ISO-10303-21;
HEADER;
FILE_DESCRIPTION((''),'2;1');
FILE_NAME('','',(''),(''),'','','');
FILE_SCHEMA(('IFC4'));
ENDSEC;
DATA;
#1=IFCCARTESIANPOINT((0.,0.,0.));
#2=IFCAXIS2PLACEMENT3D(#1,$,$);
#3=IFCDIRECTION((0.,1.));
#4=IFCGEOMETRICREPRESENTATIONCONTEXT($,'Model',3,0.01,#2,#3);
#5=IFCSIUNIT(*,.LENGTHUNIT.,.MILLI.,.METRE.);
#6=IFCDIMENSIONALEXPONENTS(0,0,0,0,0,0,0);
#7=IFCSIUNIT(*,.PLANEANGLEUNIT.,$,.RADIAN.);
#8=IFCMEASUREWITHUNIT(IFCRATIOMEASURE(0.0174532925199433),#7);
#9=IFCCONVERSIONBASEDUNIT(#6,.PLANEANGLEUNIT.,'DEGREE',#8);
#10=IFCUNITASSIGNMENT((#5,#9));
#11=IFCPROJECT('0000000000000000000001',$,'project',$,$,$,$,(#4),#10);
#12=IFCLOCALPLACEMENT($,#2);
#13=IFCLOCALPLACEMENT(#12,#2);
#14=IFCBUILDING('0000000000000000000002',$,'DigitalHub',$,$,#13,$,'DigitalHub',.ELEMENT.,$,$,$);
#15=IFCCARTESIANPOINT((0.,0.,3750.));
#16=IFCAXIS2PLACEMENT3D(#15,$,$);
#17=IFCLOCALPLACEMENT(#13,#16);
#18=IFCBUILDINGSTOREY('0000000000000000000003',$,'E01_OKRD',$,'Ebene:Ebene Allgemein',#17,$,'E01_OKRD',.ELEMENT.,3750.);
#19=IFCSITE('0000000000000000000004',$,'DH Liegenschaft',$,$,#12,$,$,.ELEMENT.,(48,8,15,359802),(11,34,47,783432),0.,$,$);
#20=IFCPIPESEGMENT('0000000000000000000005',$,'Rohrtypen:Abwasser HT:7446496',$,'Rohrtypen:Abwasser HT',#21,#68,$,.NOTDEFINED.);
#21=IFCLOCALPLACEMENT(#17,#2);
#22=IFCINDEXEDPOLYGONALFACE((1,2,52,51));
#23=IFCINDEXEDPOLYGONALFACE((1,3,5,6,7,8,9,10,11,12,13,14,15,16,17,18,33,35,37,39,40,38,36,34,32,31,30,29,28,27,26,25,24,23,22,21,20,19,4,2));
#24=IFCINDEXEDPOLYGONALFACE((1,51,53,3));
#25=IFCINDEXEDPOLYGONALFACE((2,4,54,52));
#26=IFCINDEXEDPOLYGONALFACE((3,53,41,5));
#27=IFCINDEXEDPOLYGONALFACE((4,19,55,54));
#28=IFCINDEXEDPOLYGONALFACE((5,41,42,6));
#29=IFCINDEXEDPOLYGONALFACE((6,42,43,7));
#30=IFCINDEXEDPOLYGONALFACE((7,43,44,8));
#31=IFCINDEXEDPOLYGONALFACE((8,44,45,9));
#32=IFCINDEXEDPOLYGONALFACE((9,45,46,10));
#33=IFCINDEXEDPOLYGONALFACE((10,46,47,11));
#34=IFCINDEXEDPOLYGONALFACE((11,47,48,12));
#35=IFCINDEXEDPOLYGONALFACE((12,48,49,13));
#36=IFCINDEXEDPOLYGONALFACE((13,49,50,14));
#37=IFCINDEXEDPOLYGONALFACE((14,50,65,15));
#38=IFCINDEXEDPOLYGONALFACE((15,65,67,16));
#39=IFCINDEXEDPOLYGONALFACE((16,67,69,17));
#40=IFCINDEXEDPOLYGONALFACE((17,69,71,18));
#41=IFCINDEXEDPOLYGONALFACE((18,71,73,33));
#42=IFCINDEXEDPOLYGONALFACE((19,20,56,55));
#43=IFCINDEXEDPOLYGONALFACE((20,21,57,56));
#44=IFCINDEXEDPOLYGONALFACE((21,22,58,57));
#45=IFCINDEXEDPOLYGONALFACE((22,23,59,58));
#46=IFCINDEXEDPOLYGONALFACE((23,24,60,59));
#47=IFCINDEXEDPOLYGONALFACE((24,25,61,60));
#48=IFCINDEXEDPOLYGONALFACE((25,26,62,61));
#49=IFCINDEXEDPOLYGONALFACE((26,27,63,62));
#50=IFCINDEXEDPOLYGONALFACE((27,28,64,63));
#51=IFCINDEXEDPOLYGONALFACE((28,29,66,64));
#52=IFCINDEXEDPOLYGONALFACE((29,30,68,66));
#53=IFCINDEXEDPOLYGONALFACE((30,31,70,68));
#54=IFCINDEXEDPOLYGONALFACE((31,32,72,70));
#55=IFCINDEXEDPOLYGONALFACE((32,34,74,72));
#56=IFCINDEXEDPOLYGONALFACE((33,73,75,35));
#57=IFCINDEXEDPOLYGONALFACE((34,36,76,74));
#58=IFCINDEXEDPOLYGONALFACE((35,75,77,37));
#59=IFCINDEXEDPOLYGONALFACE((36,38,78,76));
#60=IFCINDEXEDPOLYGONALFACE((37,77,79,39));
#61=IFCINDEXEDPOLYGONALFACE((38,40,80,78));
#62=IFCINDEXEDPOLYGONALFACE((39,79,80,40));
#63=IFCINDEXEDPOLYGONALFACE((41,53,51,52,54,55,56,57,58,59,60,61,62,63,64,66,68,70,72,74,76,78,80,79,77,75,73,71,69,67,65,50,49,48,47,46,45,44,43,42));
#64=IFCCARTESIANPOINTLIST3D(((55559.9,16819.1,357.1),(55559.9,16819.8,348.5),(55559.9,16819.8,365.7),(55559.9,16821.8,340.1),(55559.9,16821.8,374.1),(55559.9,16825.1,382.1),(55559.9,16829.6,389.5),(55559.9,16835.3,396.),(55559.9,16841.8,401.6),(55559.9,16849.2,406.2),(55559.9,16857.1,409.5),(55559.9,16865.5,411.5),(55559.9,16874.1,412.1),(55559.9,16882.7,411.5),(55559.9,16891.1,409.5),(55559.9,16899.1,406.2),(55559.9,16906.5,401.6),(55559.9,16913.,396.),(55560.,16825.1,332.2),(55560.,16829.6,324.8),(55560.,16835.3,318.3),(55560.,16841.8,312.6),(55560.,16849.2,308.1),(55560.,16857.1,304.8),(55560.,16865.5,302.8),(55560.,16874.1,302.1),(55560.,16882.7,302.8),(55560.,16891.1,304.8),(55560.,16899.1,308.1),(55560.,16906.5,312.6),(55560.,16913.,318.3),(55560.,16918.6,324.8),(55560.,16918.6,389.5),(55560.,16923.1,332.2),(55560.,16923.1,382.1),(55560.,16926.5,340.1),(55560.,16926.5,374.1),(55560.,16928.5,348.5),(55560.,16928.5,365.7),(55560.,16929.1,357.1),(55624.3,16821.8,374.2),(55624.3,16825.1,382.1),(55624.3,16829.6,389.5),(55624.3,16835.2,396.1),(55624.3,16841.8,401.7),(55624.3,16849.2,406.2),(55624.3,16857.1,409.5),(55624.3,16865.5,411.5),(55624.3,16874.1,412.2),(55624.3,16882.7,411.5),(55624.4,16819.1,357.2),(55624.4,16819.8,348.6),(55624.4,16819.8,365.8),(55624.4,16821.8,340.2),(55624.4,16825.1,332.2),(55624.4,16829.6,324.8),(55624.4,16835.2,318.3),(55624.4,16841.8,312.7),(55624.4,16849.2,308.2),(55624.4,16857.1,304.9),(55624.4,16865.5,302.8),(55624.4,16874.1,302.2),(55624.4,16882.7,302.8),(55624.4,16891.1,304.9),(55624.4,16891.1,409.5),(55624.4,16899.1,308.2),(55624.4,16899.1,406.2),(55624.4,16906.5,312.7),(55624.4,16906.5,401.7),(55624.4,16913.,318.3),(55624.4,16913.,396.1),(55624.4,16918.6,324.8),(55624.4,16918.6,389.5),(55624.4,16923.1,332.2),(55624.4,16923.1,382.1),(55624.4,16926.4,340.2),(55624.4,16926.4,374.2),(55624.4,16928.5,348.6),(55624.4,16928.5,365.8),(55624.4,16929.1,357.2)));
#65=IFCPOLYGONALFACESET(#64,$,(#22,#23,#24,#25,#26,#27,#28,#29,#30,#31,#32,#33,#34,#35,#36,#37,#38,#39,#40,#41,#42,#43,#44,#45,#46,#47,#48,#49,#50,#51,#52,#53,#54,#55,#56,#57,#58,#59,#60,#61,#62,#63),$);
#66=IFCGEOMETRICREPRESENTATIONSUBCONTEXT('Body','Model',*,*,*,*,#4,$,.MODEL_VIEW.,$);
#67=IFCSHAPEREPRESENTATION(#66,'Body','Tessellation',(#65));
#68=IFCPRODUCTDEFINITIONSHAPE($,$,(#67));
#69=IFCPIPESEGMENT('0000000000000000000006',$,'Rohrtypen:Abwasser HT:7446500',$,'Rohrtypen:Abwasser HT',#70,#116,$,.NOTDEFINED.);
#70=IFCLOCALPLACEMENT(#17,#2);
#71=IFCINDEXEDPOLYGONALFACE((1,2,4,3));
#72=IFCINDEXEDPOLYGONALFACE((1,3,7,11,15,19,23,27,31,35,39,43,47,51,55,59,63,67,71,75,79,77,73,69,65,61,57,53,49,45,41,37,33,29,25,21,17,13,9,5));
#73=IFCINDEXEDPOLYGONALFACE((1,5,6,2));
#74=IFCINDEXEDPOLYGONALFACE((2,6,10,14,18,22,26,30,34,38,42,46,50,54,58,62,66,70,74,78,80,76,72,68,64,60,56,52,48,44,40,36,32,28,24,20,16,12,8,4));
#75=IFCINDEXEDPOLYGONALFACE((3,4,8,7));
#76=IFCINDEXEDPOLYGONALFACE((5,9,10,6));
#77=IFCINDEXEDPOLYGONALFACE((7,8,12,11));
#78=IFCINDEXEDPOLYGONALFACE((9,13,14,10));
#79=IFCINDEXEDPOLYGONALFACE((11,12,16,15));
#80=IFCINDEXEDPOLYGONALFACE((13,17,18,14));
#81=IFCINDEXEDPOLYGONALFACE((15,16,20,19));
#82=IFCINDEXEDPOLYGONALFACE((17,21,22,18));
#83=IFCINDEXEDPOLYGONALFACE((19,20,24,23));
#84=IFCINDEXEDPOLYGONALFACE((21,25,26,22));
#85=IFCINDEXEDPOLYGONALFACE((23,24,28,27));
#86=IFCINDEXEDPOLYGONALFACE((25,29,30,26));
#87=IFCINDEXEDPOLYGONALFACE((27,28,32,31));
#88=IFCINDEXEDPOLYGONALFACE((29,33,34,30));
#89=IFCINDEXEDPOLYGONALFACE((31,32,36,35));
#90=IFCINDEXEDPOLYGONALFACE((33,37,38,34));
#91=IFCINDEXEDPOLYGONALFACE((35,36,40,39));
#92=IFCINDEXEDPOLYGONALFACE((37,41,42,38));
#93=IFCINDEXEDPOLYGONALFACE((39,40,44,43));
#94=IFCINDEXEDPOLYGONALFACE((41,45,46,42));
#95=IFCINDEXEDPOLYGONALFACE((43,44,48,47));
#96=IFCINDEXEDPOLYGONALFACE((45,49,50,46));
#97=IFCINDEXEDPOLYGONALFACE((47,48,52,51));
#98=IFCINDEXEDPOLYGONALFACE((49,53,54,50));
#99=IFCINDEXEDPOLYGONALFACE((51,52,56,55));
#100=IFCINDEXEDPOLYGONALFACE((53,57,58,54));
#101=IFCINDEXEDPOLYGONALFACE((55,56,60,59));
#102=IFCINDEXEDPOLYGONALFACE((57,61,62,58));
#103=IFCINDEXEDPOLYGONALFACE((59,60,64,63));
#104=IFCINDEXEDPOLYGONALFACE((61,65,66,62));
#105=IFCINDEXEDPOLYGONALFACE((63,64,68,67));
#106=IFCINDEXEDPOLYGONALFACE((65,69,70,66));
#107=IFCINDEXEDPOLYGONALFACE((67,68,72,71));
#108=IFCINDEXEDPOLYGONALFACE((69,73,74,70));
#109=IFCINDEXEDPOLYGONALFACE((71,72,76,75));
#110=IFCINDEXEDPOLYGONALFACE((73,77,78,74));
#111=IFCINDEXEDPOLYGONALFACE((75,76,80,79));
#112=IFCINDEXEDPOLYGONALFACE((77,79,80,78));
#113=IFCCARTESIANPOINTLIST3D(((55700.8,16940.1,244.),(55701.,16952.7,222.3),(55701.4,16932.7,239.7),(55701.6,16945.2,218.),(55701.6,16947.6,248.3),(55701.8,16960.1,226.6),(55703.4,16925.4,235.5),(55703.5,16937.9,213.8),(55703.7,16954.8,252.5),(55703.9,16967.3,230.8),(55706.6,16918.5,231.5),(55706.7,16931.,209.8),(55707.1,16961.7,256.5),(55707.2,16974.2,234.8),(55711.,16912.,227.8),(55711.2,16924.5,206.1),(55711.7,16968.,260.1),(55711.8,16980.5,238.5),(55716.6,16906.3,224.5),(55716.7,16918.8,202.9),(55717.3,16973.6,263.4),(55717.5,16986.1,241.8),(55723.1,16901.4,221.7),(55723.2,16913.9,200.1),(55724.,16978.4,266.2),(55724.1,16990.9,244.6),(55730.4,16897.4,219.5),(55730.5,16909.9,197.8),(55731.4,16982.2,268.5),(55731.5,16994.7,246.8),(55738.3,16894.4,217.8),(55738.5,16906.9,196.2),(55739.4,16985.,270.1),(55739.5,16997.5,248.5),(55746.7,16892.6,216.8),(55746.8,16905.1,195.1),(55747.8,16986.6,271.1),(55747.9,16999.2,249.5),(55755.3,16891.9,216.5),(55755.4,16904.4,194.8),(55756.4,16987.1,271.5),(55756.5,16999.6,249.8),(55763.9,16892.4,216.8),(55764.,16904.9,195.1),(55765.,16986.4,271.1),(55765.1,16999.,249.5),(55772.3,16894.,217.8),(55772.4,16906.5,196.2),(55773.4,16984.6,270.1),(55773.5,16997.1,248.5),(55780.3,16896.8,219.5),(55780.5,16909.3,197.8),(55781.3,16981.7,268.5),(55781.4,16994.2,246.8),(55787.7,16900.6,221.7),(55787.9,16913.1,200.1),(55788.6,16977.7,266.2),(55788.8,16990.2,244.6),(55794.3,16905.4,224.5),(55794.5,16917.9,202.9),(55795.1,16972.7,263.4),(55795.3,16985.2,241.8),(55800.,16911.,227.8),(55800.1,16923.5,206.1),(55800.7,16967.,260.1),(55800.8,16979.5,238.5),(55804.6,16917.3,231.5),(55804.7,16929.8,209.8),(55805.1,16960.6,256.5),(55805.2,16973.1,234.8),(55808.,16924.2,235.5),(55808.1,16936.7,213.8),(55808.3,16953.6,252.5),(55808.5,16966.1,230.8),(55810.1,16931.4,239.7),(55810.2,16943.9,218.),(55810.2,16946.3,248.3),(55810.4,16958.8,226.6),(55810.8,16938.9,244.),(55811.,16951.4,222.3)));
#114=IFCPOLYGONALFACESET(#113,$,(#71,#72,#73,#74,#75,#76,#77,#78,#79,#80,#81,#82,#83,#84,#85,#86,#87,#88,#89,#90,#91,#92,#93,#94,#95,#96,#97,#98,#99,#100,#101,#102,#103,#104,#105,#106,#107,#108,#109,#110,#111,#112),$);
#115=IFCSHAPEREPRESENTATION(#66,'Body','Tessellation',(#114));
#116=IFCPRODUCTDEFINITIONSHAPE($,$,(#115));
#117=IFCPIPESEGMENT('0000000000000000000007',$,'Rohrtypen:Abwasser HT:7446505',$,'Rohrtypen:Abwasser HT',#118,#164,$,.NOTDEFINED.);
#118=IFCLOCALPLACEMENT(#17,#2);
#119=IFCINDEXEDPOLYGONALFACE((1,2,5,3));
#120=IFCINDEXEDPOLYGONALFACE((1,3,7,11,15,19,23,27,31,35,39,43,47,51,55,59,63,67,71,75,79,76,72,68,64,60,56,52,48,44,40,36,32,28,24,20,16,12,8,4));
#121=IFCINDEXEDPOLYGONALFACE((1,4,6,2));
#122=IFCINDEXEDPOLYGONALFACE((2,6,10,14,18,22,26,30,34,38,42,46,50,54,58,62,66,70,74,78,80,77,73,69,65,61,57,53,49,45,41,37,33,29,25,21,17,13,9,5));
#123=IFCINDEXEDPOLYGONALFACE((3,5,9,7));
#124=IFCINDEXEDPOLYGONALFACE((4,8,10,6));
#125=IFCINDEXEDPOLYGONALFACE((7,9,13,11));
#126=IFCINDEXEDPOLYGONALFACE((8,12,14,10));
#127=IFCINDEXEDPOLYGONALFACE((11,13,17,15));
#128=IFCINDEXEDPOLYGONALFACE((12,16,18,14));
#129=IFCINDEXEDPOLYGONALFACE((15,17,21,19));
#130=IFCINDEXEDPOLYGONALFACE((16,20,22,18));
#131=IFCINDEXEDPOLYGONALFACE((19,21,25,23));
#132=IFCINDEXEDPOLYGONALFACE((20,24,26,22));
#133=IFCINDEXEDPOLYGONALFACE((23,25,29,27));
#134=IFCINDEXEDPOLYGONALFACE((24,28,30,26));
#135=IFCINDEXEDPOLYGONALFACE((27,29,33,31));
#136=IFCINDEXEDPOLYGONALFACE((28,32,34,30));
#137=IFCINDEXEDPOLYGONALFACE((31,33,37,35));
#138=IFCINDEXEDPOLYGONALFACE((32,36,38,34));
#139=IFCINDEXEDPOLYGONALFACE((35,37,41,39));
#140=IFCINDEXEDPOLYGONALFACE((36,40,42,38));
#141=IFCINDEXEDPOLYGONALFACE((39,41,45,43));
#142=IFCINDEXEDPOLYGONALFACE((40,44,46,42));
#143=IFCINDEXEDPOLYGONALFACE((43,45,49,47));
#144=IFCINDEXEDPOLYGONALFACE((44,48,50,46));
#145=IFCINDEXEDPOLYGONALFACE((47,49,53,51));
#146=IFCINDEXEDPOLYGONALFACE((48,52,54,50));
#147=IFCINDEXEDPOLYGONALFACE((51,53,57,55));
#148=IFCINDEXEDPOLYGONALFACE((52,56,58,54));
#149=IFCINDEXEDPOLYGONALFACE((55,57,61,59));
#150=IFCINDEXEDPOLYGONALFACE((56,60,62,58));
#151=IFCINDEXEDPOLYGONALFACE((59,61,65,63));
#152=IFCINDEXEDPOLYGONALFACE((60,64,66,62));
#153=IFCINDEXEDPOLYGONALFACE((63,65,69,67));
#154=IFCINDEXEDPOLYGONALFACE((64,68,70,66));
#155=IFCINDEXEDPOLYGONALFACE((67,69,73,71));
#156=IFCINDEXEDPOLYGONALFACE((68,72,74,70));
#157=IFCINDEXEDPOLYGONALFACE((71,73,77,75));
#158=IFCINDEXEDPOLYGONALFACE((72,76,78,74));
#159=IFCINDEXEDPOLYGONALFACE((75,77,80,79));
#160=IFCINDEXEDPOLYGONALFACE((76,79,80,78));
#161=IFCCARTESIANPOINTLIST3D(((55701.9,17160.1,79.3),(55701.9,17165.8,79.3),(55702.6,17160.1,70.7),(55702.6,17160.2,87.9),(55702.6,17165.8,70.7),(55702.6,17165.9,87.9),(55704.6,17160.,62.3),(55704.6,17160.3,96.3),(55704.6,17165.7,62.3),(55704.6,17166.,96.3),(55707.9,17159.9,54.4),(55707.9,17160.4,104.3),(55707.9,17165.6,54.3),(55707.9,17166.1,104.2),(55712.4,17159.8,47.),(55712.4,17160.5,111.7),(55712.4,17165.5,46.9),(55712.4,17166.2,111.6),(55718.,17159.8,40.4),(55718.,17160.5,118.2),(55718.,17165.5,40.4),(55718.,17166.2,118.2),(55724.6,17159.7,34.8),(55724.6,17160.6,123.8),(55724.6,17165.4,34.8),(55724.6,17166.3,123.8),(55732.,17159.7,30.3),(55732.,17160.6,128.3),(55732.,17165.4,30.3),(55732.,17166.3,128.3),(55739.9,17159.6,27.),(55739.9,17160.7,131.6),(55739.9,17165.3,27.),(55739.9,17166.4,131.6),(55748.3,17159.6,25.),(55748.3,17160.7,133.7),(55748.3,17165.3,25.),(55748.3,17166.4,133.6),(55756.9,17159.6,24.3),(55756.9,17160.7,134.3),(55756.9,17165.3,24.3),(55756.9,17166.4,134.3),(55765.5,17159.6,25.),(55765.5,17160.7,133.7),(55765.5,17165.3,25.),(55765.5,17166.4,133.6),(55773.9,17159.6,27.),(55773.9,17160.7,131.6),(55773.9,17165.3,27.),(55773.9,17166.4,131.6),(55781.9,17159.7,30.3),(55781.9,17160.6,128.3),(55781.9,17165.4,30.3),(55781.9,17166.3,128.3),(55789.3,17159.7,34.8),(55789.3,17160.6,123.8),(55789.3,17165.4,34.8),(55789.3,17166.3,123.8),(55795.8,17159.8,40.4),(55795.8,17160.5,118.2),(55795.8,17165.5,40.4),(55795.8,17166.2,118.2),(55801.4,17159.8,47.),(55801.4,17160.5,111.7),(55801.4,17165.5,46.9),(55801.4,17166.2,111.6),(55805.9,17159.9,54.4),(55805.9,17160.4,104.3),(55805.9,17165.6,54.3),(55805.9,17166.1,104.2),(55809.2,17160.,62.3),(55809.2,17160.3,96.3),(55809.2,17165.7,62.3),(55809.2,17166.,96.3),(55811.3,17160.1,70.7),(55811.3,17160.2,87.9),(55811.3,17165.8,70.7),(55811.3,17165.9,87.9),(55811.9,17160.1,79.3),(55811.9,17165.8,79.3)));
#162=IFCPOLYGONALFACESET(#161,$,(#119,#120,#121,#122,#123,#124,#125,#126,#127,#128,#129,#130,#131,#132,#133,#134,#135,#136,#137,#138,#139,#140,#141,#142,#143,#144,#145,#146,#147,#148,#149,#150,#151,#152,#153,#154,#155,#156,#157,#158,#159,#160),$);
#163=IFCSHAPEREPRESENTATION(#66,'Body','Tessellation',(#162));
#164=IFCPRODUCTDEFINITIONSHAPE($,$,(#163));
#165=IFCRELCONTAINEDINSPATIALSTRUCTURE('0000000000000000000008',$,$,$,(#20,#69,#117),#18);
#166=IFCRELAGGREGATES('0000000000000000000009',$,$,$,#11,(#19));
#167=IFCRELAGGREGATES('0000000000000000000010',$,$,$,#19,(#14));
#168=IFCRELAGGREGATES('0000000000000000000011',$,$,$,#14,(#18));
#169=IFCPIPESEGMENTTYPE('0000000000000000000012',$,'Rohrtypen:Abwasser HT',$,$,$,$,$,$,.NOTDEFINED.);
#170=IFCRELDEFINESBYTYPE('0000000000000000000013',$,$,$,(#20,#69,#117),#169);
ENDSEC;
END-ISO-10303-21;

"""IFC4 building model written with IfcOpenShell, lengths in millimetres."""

from ifc_helpers import new_model, entity, si_unit, converted_unit, direction, frame, origin, place, context, subcontext, project, spatial, indexed_curve, outline, extrude, type_object, element, save


model = new_model("IFC4")

# Units and contexts
model_context = context("Model", 3, precision=0.01, world=origin(), true_north=direction((0.0, 1.0)))
body_context = subcontext(model_context, "Body", "Model", "MODEL_VIEW")
ifc_project = project(units=[si_unit("LENGTHUNIT", "METRE", prefix="MILLI"), converted_unit("PLANEANGLEUNIT", "DEGREE", entity("IfcRatioMeasure", 0.0174532925199433), si_unit("PLANEANGLEUNIT", "RADIAN"), dimensions=[0, 0, 0, 0, 0, 0, 0])], contexts=[model_context])

# Site, building, storey
site_placement = place(None, origin())
site = spatial("IfcSite", under=ifc_project, at=site_placement, Name="DH Liegenschaft", CompositionType="ELEMENT", RefLatitude=(48, 8, 15, 359802), RefLongitude=(11, 34, 47, 783432), RefElevation=0.0)
building_placement = place(site_placement, origin())
building = spatial("IfcBuilding", under=site, at=building_placement, Name="DigitalHub", LongName="DigitalHub", CompositionType="ELEMENT")
storey_placement = place(building_placement, frame((0.0, 0.0, 3750.0)))
storey = spatial("IfcBuildingStorey", under=building, at=storey_placement, Name="E01_OKRD", ObjectType="Ebene:Ebene Allgemein", LongName="E01_OKRD", CompositionType="ELEMENT", Elevation=3750.0)

# Pipe segments
pipe_segment_type_1 = type_object("IfcPipeSegmentType", Name="Rohrtypen:Abwasser HT", PredefinedType="NOTDEFINED")
pipe_segment_1_placement = place(storey_placement, frame((55559.9, 16817.5, 300.5)))
element("IfcPipeSegment", 1, at=pipe_segment_1_placement, inside=storey, type_object=pipe_segment_type_1, Name="Rohrtypen:Abwasser HT:7446496", ObjectType="Rohrtypen:Abwasser HT", PredefinedType="NOTDEFINED", context=body_context, shape_type="SweptSolid", body=[
    extrude(outline(indexed_curve([(55.0, 0.0), (54.3, 8.6), (52.3, 17.0), (49.0, 25.0), (44.5, 32.3), (38.9, 38.9), (32.3, 44.5), (25.0, 49.0), (17.0, 52.3), (8.6, 54.3), (0.0, 55.0), (-8.6, 54.3), (-17.0, 52.3), (-25.0, 49.0), (-32.3, 44.5), (-38.9, 38.9), (-44.5, 32.3), (-49.0, 25.0), (-52.3, 17.0), (-54.3, 8.6), (-55.0, 0.0), (-54.3, -8.6), (-52.3, -17.0), (-49.0, -25.0), (-44.5, -32.3), (-38.9, -38.9), (-32.3, -44.5), (-25.0, -49.0), (-17.0, -52.3), (-8.6, -54.3), (0.0, -55.0), (8.6, -54.3), (17.0, -52.3), (25.0, -49.0), (32.3, -44.5), (38.9, -38.9), (44.5, -32.3), (49.0, -25.0), (52.3, -17.0), (54.3, -8.6), (55.0, 0.0)], self_intersect=False)), frame((64.4, 56.6, 56.6), z_axis=(-1.0, 0.000208, -0.000342), x_axis=(-0.000208, -1.0, 0.0)), (0.0, 0.0, 1.0), 64.4),
])
pipe_segment_2_placement = place(storey_placement, frame((55699.2, 16890.3, 193.2)))
element("IfcPipeSegment", 2, at=pipe_segment_2_placement, inside=storey, type_object=pipe_segment_type_1, Name="Rohrtypen:Abwasser HT:7446500", ObjectType="Rohrtypen:Abwasser HT", PredefinedType="NOTDEFINED", context=body_context, shape_type="SweptSolid", body=[
    extrude(outline(indexed_curve([(55.0, 0.0), (54.3, 8.6), (52.3, 17.0), (49.0, 25.0), (44.5, 32.3), (38.9, 38.9), (32.3, 44.5), (25.0, 49.0), (17.0, 52.3), (8.6, 54.3), (0.0, 55.0), (-8.6, 54.3), (-17.0, 52.3), (-25.0, 49.0), (-32.3, 44.5), (-38.9, 38.9), (-44.5, 32.3), (-49.0, 25.0), (-52.3, 17.0), (-54.3, 8.6), (-55.0, 0.0), (-54.3, -8.6), (-52.3, -17.0), (-49.0, -25.0), (-44.5, -32.3), (-38.9, -38.9), (-32.3, -44.5), (-25.0, -49.0), (-17.0, -52.3), (-8.6, -54.3), (0.0, -55.0), (8.6, -54.3), (17.0, -52.3), (25.0, -49.0), (32.3, -44.5), (38.9, -38.9), (44.5, -32.3), (49.0, -25.0), (52.3, -17.0), (54.3, -8.6), (55.0, 0.0)], self_intersect=False)), frame((56.6, 49.2, 50.8), z_axis=(0.005834, 0.499991, -0.866011), x_axis=(0.999932, -0.011668, 0.0)), (0.0, 0.0, 1.0), 25.0),
])
pipe_segment_3_placement = place(storey_placement, frame((55700.3, 17158.0, 22.7)))
element("IfcPipeSegment", 3, at=pipe_segment_3_placement, inside=storey, type_object=pipe_segment_type_1, Name="Rohrtypen:Abwasser HT:7446505", ObjectType="Rohrtypen:Abwasser HT", PredefinedType="NOTDEFINED", context=body_context, shape_type="SweptSolid", body=[
    extrude(outline(indexed_curve([(55.0, 0.0), (54.3, 8.6), (52.3, 17.0), (49.0, 25.0), (44.5, 32.3), (38.9, 38.9), (32.3, 44.5), (25.0, 49.0), (17.0, 52.3), (8.6, 54.3), (0.0, 55.0), (-8.6, 54.3), (-17.0, 52.3), (-25.0, 49.0), (-32.3, 44.5), (-38.9, 38.9), (-44.5, 32.3), (-49.0, 25.0), (-52.3, 17.0), (-54.3, 8.6), (-55.0, 0.0), (-54.3, -8.6), (-52.3, -17.0), (-49.0, -25.0), (-44.5, -32.3), (-38.9, -38.9), (-32.3, -44.5), (-25.0, -49.0), (-17.0, -52.3), (-8.6, -54.3), (0.0, -55.0), (8.6, -54.3), (17.0, -52.3), (25.0, -49.0), (32.3, -44.5), (38.9, -38.9), (44.5, -32.3), (49.0, -25.0), (52.3, -17.0), (54.3, -8.6), (55.0, 0.0)], self_intersect=False)), frame((56.6, 2.1, 56.6), z_axis=(0.0, 0.99995, -0.010016), x_axis=(1.0, 0.0, 0.0)), (0.0, 0.0, 1.0), 5.7),
])

save(model, "model.ifc")
